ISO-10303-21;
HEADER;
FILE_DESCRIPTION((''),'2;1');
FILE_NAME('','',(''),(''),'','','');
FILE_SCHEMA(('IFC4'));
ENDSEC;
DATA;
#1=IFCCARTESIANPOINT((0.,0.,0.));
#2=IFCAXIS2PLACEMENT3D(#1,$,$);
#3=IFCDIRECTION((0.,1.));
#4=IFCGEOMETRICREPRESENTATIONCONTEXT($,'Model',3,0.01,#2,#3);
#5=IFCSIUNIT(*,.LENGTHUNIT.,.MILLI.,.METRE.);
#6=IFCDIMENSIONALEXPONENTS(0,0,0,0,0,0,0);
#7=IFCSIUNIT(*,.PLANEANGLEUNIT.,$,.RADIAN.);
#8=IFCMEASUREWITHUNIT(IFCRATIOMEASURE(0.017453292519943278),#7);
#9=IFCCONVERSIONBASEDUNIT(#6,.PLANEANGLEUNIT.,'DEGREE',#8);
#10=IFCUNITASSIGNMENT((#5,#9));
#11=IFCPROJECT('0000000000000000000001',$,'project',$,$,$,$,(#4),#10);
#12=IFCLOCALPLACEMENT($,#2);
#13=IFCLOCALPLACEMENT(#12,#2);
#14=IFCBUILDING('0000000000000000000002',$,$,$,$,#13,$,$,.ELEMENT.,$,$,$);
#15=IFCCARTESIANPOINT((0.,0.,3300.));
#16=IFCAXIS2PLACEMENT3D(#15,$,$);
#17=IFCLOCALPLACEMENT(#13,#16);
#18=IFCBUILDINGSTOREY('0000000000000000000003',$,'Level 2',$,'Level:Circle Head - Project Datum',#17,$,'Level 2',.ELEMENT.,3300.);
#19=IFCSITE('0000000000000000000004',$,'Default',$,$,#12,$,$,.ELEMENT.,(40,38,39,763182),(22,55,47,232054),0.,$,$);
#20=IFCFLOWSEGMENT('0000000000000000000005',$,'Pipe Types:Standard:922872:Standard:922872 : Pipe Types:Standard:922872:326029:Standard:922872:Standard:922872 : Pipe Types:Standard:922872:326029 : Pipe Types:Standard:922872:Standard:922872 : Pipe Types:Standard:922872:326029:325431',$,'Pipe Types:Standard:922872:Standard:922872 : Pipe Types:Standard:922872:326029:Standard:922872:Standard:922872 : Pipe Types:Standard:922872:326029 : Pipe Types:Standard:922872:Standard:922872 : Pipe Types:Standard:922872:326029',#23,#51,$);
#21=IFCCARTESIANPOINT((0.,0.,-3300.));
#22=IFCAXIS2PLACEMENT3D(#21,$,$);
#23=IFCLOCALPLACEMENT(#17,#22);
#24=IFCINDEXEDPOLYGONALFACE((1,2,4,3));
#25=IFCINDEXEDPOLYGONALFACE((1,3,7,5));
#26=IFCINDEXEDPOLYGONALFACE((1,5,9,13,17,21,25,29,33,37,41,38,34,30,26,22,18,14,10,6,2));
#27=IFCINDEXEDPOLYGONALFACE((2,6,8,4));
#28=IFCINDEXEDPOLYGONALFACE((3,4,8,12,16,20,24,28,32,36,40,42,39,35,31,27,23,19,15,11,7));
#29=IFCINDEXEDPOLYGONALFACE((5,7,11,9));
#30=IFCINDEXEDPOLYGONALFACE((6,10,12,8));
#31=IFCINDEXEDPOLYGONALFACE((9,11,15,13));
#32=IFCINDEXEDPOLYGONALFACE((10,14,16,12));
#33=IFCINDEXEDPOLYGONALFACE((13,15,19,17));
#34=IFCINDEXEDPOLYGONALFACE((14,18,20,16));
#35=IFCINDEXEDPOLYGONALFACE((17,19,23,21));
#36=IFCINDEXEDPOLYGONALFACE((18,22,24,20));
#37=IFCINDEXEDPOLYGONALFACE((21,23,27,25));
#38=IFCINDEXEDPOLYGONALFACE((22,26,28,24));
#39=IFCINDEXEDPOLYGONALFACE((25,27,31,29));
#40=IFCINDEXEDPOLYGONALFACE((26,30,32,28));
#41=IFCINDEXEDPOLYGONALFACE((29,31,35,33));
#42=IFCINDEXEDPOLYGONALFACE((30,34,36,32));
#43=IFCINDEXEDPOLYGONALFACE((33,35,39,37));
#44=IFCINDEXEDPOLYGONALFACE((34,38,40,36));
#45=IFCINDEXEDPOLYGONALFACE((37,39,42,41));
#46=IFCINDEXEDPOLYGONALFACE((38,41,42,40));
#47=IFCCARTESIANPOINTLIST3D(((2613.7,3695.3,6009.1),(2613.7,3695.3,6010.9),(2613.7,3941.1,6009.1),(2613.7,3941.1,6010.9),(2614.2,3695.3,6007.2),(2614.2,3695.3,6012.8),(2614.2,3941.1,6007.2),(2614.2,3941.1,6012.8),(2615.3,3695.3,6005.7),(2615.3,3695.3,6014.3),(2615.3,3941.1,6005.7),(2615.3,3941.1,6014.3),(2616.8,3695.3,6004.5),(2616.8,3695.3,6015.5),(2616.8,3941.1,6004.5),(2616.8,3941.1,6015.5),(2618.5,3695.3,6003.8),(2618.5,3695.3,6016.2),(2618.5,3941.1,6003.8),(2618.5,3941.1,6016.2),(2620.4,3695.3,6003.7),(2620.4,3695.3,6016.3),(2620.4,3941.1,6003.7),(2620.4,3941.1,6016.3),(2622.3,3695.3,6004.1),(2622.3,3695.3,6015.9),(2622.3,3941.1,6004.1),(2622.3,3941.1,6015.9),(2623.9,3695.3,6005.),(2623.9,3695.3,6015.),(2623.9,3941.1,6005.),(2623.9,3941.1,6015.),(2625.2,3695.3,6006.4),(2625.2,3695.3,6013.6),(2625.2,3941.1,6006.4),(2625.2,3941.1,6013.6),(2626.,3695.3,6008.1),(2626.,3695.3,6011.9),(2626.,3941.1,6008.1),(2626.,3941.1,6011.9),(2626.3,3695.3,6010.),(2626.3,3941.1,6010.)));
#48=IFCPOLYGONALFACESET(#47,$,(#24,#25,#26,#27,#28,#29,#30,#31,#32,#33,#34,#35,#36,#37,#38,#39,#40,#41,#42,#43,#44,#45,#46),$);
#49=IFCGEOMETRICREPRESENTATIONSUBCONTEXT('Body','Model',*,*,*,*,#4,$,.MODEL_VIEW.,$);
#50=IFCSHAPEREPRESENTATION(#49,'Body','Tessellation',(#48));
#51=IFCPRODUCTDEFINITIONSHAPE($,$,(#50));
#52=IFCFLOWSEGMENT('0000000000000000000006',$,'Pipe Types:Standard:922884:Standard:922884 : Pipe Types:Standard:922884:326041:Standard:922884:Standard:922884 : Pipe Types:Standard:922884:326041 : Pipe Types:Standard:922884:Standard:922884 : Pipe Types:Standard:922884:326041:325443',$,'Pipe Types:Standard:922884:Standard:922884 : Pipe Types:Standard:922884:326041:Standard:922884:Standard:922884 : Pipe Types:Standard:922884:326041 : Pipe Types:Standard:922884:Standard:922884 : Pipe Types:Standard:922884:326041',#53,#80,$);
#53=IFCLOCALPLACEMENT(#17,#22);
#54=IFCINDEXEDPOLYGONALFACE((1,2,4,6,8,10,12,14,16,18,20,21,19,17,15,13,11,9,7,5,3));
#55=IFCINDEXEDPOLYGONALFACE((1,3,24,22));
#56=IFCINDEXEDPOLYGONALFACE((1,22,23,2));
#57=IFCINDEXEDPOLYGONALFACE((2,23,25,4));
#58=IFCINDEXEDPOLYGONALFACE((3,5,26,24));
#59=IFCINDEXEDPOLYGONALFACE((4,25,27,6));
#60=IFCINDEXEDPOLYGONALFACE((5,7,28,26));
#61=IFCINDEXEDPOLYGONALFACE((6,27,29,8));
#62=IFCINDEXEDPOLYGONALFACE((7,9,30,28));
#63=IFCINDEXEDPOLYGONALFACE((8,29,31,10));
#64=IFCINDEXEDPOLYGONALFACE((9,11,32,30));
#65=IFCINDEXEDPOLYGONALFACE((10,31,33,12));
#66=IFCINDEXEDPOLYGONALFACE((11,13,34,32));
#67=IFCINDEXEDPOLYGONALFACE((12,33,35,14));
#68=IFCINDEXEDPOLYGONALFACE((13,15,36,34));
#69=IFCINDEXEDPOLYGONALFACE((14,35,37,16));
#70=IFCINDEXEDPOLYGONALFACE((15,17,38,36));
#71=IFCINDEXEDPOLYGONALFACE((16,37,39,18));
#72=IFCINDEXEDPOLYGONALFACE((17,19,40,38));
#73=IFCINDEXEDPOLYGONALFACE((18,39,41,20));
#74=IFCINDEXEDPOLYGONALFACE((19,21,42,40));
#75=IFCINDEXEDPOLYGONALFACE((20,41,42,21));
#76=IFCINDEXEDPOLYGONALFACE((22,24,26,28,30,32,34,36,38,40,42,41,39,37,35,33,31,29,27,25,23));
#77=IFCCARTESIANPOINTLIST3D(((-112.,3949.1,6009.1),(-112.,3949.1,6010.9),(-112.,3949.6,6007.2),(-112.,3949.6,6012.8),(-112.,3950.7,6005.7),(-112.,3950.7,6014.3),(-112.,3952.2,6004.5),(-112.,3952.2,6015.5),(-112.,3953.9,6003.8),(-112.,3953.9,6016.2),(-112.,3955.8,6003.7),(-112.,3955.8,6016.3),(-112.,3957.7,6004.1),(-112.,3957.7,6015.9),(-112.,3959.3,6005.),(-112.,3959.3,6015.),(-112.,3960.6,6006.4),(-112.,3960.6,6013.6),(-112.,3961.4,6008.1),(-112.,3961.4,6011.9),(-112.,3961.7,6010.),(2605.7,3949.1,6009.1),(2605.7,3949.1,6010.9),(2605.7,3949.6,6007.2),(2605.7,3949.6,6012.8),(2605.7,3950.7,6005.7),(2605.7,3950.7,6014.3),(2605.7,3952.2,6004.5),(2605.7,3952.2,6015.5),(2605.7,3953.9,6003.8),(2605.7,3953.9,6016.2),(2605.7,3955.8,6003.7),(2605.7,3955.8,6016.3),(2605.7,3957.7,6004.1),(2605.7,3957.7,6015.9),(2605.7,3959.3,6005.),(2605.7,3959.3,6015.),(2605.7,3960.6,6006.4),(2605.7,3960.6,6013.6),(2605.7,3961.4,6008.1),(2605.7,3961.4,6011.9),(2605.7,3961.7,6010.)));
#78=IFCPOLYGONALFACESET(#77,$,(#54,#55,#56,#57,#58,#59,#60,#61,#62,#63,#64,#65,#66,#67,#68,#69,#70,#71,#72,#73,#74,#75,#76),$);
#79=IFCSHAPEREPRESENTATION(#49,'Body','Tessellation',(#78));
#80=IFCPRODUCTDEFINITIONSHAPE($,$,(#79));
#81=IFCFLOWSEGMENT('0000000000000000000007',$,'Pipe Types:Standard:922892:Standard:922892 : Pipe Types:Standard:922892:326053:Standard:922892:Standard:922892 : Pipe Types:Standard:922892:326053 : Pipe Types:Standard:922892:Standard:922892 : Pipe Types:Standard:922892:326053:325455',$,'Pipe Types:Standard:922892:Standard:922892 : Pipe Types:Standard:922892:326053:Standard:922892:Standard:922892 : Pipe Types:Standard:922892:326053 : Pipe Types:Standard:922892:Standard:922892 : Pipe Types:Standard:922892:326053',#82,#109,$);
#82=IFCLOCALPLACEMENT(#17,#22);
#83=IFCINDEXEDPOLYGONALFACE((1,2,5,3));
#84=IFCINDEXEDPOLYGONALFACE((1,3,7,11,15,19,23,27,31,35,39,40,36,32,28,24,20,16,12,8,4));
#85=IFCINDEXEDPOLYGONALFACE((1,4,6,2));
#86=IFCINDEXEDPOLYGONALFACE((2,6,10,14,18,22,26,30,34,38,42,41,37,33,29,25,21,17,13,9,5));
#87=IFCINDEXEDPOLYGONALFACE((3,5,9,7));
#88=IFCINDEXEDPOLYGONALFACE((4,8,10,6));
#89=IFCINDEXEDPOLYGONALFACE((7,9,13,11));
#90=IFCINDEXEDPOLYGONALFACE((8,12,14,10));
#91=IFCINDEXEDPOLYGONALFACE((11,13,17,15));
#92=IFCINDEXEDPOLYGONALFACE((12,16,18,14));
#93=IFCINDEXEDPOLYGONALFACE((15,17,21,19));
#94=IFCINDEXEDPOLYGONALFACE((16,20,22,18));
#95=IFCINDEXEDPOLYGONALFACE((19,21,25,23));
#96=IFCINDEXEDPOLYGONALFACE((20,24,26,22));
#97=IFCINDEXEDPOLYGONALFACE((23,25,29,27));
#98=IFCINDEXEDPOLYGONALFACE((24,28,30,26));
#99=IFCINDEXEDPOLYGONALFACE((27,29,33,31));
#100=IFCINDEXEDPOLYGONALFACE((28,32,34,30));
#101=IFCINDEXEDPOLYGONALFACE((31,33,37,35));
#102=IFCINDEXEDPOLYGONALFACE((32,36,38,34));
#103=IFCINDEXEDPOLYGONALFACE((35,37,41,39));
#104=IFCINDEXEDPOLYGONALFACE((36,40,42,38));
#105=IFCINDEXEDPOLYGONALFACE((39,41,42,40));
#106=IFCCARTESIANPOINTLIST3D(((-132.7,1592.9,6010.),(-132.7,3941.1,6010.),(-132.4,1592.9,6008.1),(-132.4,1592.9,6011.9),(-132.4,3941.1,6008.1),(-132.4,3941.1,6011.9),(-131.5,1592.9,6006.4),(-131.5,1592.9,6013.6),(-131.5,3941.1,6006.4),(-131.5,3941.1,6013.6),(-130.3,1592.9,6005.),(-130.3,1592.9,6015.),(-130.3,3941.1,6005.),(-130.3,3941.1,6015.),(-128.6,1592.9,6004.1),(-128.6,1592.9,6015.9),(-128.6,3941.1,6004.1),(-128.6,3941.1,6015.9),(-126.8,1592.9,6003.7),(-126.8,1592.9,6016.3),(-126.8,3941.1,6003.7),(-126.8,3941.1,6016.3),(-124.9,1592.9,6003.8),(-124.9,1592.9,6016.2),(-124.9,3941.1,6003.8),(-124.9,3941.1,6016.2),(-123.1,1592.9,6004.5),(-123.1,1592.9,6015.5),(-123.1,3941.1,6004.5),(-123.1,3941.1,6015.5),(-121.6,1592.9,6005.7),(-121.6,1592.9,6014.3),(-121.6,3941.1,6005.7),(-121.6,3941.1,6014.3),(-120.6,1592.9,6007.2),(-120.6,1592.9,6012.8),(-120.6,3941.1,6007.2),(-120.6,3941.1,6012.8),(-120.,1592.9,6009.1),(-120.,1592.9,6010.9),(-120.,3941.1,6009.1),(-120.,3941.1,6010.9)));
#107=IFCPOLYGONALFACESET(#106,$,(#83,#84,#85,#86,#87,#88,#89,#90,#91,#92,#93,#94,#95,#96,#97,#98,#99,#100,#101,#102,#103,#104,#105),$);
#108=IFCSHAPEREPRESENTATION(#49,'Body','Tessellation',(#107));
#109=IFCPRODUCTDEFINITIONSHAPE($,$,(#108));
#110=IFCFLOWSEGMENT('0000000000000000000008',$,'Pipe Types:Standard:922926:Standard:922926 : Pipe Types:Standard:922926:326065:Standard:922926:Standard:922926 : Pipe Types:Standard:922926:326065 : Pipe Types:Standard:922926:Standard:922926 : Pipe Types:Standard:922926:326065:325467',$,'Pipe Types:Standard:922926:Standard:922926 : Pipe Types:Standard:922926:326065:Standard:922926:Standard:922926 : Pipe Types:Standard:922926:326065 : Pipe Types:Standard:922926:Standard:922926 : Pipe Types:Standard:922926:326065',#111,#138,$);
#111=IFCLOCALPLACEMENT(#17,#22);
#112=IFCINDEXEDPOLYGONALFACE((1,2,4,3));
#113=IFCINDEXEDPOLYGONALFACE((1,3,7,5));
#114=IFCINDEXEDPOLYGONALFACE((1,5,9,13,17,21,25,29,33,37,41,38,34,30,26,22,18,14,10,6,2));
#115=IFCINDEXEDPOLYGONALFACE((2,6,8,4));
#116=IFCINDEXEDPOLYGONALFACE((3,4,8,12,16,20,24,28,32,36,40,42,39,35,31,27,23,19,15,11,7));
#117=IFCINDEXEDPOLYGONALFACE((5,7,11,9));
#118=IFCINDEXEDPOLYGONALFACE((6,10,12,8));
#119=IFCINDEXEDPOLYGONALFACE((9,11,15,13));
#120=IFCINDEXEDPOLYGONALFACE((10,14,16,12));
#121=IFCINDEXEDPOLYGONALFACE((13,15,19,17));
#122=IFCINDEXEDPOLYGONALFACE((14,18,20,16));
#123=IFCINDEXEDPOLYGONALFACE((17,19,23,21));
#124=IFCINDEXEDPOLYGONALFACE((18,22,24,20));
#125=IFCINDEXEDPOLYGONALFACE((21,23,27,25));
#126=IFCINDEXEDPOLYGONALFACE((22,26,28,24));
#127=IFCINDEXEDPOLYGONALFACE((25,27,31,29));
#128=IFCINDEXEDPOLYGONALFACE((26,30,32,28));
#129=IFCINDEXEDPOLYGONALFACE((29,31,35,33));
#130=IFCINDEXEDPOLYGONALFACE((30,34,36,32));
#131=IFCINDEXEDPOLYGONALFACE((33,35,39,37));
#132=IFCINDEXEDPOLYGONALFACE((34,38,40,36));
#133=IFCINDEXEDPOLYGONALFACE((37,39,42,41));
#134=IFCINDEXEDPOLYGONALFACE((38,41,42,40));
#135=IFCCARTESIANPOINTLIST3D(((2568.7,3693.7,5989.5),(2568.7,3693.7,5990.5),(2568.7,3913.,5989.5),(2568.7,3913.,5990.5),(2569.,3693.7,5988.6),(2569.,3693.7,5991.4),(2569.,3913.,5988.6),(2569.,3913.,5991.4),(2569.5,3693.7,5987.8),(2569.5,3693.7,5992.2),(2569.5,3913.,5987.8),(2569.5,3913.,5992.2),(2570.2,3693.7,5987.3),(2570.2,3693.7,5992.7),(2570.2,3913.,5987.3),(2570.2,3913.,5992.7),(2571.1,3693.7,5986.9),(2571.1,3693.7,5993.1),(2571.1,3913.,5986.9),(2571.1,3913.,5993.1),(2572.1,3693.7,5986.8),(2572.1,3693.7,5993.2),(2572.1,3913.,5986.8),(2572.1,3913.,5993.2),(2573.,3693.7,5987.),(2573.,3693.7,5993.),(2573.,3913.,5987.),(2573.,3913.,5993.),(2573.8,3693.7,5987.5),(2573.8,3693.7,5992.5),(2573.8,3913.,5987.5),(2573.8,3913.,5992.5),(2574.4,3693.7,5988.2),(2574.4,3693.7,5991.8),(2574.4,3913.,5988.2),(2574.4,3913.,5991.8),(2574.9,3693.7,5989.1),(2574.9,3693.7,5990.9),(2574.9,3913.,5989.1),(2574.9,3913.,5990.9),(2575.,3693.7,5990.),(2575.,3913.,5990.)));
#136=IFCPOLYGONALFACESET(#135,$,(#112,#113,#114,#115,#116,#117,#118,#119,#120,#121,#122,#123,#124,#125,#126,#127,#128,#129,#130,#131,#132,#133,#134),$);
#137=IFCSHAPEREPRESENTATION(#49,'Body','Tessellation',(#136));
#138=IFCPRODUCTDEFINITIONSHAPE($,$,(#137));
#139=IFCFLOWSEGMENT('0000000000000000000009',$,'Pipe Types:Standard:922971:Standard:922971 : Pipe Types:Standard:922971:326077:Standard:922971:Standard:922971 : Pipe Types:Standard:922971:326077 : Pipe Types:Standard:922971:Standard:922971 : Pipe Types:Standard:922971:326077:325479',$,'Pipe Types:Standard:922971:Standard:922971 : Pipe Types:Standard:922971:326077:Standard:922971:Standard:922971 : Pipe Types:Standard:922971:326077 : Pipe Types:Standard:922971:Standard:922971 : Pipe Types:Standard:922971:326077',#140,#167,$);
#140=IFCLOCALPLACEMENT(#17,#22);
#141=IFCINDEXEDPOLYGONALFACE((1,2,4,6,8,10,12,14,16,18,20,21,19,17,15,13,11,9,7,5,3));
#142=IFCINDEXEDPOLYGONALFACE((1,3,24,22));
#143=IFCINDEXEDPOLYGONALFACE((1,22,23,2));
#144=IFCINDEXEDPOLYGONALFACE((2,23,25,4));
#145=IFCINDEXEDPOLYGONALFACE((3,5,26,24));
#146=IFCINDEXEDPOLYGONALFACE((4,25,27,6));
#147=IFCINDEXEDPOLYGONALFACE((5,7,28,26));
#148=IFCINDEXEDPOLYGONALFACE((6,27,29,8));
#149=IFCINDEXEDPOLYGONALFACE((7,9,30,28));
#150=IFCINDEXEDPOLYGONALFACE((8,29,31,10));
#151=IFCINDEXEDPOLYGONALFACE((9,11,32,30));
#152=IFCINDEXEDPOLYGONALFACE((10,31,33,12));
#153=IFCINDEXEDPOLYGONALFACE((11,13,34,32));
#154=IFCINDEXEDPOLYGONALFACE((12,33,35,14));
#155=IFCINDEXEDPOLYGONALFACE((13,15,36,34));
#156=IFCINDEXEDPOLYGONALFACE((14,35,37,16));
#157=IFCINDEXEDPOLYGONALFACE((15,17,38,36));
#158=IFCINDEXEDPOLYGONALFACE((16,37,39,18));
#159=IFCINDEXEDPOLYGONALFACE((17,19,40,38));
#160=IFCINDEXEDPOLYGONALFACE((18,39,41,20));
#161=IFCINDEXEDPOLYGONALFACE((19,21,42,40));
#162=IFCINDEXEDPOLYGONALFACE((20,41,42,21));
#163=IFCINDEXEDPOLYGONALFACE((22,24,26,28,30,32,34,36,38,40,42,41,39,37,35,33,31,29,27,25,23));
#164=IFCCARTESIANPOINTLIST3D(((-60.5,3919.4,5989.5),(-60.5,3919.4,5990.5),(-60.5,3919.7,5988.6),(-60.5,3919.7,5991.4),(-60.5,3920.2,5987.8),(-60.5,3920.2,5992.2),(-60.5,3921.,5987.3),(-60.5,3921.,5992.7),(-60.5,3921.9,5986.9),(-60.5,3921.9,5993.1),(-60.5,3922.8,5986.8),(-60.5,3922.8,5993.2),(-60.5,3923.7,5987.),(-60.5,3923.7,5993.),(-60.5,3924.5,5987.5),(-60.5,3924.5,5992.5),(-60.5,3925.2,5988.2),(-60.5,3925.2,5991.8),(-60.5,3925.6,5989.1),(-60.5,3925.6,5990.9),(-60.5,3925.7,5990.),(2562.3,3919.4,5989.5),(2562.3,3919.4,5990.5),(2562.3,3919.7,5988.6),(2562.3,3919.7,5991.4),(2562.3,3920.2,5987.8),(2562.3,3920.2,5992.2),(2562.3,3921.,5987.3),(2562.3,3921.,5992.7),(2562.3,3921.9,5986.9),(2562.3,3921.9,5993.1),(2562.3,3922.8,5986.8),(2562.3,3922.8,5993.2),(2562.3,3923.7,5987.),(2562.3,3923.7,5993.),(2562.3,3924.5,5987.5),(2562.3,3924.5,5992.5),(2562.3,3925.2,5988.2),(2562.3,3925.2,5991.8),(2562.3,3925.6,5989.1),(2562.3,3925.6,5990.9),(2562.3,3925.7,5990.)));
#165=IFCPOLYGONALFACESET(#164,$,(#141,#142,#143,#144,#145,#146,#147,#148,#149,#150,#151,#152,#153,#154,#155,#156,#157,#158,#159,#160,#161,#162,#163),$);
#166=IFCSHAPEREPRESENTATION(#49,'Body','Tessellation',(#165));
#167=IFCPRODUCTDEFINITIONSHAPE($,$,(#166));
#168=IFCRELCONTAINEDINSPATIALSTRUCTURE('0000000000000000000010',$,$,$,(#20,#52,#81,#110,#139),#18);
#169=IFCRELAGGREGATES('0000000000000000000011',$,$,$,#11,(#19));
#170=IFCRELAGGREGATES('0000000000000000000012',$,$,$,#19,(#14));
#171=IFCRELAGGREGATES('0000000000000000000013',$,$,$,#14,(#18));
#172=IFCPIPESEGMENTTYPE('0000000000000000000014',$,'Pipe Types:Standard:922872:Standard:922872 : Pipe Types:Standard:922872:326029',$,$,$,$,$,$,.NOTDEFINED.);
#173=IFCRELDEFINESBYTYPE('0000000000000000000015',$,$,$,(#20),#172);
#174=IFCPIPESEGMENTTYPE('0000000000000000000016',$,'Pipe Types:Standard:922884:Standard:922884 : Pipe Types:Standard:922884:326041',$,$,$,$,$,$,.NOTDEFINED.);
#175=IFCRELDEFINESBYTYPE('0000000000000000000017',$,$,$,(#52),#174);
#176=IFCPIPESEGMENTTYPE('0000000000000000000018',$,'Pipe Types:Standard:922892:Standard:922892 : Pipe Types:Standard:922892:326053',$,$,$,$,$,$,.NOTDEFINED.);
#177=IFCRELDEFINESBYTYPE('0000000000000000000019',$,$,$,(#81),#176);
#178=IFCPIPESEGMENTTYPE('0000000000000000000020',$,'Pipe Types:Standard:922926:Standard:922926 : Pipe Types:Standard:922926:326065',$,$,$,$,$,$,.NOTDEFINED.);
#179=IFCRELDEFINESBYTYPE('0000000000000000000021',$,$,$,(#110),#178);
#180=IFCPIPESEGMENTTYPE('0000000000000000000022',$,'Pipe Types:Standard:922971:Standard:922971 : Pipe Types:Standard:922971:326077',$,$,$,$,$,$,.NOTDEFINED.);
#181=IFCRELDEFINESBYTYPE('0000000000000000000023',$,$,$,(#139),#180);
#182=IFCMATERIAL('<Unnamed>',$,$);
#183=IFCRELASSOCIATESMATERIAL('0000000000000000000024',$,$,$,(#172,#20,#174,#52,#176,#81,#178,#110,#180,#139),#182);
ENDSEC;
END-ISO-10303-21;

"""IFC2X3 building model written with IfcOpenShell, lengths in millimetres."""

from ifc_helpers import new_model, entity, si_unit, converted_unit, direction, frame, origin, origin_2d_with_axis, place, context, subcontext, project, spatial, circle, extrude, source, transform, mapped, material, type_object, type_shapes, element, save


model = new_model("IFC2X3")

# Units and contexts
model_context = context("Model", 3, precision=0.01, world=origin(), true_north=direction((0.0, 1.0)))
body_context = subcontext(model_context, "Body", "Model", "MODEL_VIEW")
ifc_project = project(units=[si_unit("LENGTHUNIT", "METRE", prefix="MILLI"), converted_unit("PLANEANGLEUNIT", "DEGREE", entity("IfcRatioMeasure", 0.017453292519943278), si_unit("PLANEANGLEUNIT", "RADIAN"), dimensions=[0, 0, 0, 0, 0, 0, 0])], contexts=[model_context])

# Site, building, storey
site_placement = place(None, origin())
site = spatial("IfcSite", under=ifc_project, at=site_placement, Name="Default", CompositionType="ELEMENT", RefLatitude=(40, 38, 39, 763182), RefLongitude=(22, 55, 47, 232054), RefElevation=0.0)
building_placement = place(site_placement, origin())
building = spatial("IfcBuilding", under=site, at=building_placement, CompositionType="ELEMENT")
storey_placement = place(building_placement, frame((0.0, 0.0, 3300.0)))
storey = spatial("IfcBuildingStorey", under=building, at=storey_placement, Name="Level 2", ObjectType="Level:Circle Head - Project Datum", LongName="Level 2", CompositionType="ELEMENT", Elevation=3300.0)

# Flow segments
ifc_material = material(Name="<Unnamed>")
pipe_segment_type_1 = type_object("IfcPipeSegmentType", Name="Pipe Types:Standard:922872:Standard:922872 : Pipe Types:Standard:922872:326029", PredefinedType="NOTDEFINED", material=ifc_material)
shared_shape_1 = source(origin(), body_context, "Body", "SweptSolid", [
    extrude(circle(Radius=6.3, at=origin_2d_with_axis()), frame((2619.9, 3695.3, 6010.0), z_axis=(0.0, 1.0, 0.0), x_axis=(1.0, 0.0, 0.0)), (0.0, 0.0, 1.0), 245.8),
])
type_shapes(pipe_segment_type_1, [shared_shape_1])
flow_segment_1_placement = place(storey_placement, frame((0.0, 0.0, -3300.0)))
element("IfcFlowSegment", 1, at=flow_segment_1_placement, inside=storey, type_object=pipe_segment_type_1, material=ifc_material, Name="Pipe Types:Standard:922872:Standard:922872 : Pipe Types:Standard:922872:326029:Standard:922872:Standard:922872 : Pipe Types:Standard:922872:326029 : Pipe Types:Standard:922872:Standard:922872 : Pipe Types:Standard:922872:326029:325431", ObjectType="Pipe Types:Standard:922872:Standard:922872 : Pipe Types:Standard:922872:326029:Standard:922872:Standard:922872 : Pipe Types:Standard:922872:326029 : Pipe Types:Standard:922872:Standard:922872 : Pipe Types:Standard:922872:326029", context=body_context, shape_type="MappedRepresentation", body=[
    mapped(shared_shape_1, transform((0.0, 0.0, 0.0), scale=1.0)),
])
pipe_segment_type_2 = type_object("IfcPipeSegmentType", Name="Pipe Types:Standard:922884:Standard:922884 : Pipe Types:Standard:922884:326041", PredefinedType="NOTDEFINED", material=ifc_material)
shared_shape_2 = source(origin(), body_context, "Body", "SweptSolid", [
    extrude(circle(Radius=6.3, at=origin_2d_with_axis()), frame((-112.0, 3955.3, 6010.0), z_axis=(1.0, 0.0, 0.0), x_axis=(0.0, 1.0, 0.0)), (0.0, 0.0, 1.0), 2717.7),
])
type_shapes(pipe_segment_type_2, [shared_shape_2])
flow_segment_2_placement = place(storey_placement, frame((0.0, 0.0, -3300.0)))
element("IfcFlowSegment", 2, at=flow_segment_2_placement, inside=storey, type_object=pipe_segment_type_2, material=ifc_material, Name="Pipe Types:Standard:922884:Standard:922884 : Pipe Types:Standard:922884:326041:Standard:922884:Standard:922884 : Pipe Types:Standard:922884:326041 : Pipe Types:Standard:922884:Standard:922884 : Pipe Types:Standard:922884:326041:325443", ObjectType="Pipe Types:Standard:922884:Standard:922884 : Pipe Types:Standard:922884:326041:Standard:922884:Standard:922884 : Pipe Types:Standard:922884:326041 : Pipe Types:Standard:922884:Standard:922884 : Pipe Types:Standard:922884:326041", context=body_context, shape_type="MappedRepresentation", body=[
    mapped(shared_shape_2, transform((0.0, 0.0, 0.0), scale=1.0)),
])
pipe_segment_type_3 = type_object("IfcPipeSegmentType", Name="Pipe Types:Standard:922892:Standard:922892 : Pipe Types:Standard:922892:326053", PredefinedType="NOTDEFINED", material=ifc_material)
shared_shape_3 = source(origin(), body_context, "Body", "SweptSolid", [
    extrude(circle(Radius=6.3, at=origin_2d_with_axis()), frame((-126.3, 1592.9, 6010.0), z_axis=(0.0, 1.0, 0.0), x_axis=(-1.0, 0.0, 0.0)), (0.0, 0.0, 1.0), 2348.2),
])
type_shapes(pipe_segment_type_3, [shared_shape_3])
flow_segment_3_placement = place(storey_placement, frame((0.0, 0.0, -3300.0)))
element("IfcFlowSegment", 3, at=flow_segment_3_placement, inside=storey, type_object=pipe_segment_type_3, material=ifc_material, Name="Pipe Types:Standard:922892:Standard:922892 : Pipe Types:Standard:922892:326053:Standard:922892:Standard:922892 : Pipe Types:Standard:922892:326053 : Pipe Types:Standard:922892:Standard:922892 : Pipe Types:Standard:922892:326053:325455", ObjectType="Pipe Types:Standard:922892:Standard:922892 : Pipe Types:Standard:922892:326053:Standard:922892:Standard:922892 : Pipe Types:Standard:922892:326053 : Pipe Types:Standard:922892:Standard:922892 : Pipe Types:Standard:922892:326053", context=body_context, shape_type="MappedRepresentation", body=[
    mapped(shared_shape_3, transform((0.0, 0.0, 0.0), scale=1.0)),
])
pipe_segment_type_4 = type_object("IfcPipeSegmentType", Name="Pipe Types:Standard:922926:Standard:922926 : Pipe Types:Standard:922926:326065", PredefinedType="NOTDEFINED", material=ifc_material)
shared_shape_4 = source(origin(), body_context, "Body", "SweptSolid", [
    extrude(circle(Radius=3.2, at=origin_2d_with_axis()), frame((2571.8, 3693.7, 5990.0), z_axis=(0.0, 1.0, 0.0), x_axis=(1.0, 0.0, 0.0)), (0.0, 0.0, 1.0), 219.3),
])
type_shapes(pipe_segment_type_4, [shared_shape_4])
flow_segment_4_placement = place(storey_placement, frame((0.0, 0.0, -3300.0)))
element("IfcFlowSegment", 4, at=flow_segment_4_placement, inside=storey, type_object=pipe_segment_type_4, material=ifc_material, Name="Pipe Types:Standard:922926:Standard:922926 : Pipe Types:Standard:922926:326065:Standard:922926:Standard:922926 : Pipe Types:Standard:922926:326065 : Pipe Types:Standard:922926:Standard:922926 : Pipe Types:Standard:922926:326065:325467", ObjectType="Pipe Types:Standard:922926:Standard:922926 : Pipe Types:Standard:922926:326065:Standard:922926:Standard:922926 : Pipe Types:Standard:922926:326065 : Pipe Types:Standard:922926:Standard:922926 : Pipe Types:Standard:922926:326065", context=body_context, shape_type="MappedRepresentation", body=[
    mapped(shared_shape_4, transform((0.0, 0.0, 0.0), scale=1.0)),
])
pipe_segment_type_5 = type_object("IfcPipeSegmentType", Name="Pipe Types:Standard:922971:Standard:922971 : Pipe Types:Standard:922971:326077", PredefinedType="NOTDEFINED", material=ifc_material)
shared_shape_5 = source(origin(), body_context, "Body", "SweptSolid", [
    extrude(circle(Radius=3.2, at=origin_2d_with_axis()), frame((-60.5, 3922.6, 5990.0), z_axis=(1.0, 0.0, 0.0), x_axis=(0.0, 1.0, 0.0)), (0.0, 0.0, 1.0), 2622.8),
])
type_shapes(pipe_segment_type_5, [shared_shape_5])
flow_segment_5_placement = place(storey_placement, frame((0.0, 0.0, -3300.0)))
element("IfcFlowSegment", 5, at=flow_segment_5_placement, inside=storey, type_object=pipe_segment_type_5, material=ifc_material, Name="Pipe Types:Standard:922971:Standard:922971 : Pipe Types:Standard:922971:326077:Standard:922971:Standard:922971 : Pipe Types:Standard:922971:326077 : Pipe Types:Standard:922971:Standard:922971 : Pipe Types:Standard:922971:326077:325479", ObjectType="Pipe Types:Standard:922971:Standard:922971 : Pipe Types:Standard:922971:326077:Standard:922971:Standard:922971 : Pipe Types:Standard:922971:326077 : Pipe Types:Standard:922971:Standard:922971 : Pipe Types:Standard:922971:326077", context=body_context, shape_type="MappedRepresentation", body=[
    mapped(shared_shape_5, transform((0.0, 0.0, 0.0), scale=1.0)),
])

save(model, "model.ifc")
